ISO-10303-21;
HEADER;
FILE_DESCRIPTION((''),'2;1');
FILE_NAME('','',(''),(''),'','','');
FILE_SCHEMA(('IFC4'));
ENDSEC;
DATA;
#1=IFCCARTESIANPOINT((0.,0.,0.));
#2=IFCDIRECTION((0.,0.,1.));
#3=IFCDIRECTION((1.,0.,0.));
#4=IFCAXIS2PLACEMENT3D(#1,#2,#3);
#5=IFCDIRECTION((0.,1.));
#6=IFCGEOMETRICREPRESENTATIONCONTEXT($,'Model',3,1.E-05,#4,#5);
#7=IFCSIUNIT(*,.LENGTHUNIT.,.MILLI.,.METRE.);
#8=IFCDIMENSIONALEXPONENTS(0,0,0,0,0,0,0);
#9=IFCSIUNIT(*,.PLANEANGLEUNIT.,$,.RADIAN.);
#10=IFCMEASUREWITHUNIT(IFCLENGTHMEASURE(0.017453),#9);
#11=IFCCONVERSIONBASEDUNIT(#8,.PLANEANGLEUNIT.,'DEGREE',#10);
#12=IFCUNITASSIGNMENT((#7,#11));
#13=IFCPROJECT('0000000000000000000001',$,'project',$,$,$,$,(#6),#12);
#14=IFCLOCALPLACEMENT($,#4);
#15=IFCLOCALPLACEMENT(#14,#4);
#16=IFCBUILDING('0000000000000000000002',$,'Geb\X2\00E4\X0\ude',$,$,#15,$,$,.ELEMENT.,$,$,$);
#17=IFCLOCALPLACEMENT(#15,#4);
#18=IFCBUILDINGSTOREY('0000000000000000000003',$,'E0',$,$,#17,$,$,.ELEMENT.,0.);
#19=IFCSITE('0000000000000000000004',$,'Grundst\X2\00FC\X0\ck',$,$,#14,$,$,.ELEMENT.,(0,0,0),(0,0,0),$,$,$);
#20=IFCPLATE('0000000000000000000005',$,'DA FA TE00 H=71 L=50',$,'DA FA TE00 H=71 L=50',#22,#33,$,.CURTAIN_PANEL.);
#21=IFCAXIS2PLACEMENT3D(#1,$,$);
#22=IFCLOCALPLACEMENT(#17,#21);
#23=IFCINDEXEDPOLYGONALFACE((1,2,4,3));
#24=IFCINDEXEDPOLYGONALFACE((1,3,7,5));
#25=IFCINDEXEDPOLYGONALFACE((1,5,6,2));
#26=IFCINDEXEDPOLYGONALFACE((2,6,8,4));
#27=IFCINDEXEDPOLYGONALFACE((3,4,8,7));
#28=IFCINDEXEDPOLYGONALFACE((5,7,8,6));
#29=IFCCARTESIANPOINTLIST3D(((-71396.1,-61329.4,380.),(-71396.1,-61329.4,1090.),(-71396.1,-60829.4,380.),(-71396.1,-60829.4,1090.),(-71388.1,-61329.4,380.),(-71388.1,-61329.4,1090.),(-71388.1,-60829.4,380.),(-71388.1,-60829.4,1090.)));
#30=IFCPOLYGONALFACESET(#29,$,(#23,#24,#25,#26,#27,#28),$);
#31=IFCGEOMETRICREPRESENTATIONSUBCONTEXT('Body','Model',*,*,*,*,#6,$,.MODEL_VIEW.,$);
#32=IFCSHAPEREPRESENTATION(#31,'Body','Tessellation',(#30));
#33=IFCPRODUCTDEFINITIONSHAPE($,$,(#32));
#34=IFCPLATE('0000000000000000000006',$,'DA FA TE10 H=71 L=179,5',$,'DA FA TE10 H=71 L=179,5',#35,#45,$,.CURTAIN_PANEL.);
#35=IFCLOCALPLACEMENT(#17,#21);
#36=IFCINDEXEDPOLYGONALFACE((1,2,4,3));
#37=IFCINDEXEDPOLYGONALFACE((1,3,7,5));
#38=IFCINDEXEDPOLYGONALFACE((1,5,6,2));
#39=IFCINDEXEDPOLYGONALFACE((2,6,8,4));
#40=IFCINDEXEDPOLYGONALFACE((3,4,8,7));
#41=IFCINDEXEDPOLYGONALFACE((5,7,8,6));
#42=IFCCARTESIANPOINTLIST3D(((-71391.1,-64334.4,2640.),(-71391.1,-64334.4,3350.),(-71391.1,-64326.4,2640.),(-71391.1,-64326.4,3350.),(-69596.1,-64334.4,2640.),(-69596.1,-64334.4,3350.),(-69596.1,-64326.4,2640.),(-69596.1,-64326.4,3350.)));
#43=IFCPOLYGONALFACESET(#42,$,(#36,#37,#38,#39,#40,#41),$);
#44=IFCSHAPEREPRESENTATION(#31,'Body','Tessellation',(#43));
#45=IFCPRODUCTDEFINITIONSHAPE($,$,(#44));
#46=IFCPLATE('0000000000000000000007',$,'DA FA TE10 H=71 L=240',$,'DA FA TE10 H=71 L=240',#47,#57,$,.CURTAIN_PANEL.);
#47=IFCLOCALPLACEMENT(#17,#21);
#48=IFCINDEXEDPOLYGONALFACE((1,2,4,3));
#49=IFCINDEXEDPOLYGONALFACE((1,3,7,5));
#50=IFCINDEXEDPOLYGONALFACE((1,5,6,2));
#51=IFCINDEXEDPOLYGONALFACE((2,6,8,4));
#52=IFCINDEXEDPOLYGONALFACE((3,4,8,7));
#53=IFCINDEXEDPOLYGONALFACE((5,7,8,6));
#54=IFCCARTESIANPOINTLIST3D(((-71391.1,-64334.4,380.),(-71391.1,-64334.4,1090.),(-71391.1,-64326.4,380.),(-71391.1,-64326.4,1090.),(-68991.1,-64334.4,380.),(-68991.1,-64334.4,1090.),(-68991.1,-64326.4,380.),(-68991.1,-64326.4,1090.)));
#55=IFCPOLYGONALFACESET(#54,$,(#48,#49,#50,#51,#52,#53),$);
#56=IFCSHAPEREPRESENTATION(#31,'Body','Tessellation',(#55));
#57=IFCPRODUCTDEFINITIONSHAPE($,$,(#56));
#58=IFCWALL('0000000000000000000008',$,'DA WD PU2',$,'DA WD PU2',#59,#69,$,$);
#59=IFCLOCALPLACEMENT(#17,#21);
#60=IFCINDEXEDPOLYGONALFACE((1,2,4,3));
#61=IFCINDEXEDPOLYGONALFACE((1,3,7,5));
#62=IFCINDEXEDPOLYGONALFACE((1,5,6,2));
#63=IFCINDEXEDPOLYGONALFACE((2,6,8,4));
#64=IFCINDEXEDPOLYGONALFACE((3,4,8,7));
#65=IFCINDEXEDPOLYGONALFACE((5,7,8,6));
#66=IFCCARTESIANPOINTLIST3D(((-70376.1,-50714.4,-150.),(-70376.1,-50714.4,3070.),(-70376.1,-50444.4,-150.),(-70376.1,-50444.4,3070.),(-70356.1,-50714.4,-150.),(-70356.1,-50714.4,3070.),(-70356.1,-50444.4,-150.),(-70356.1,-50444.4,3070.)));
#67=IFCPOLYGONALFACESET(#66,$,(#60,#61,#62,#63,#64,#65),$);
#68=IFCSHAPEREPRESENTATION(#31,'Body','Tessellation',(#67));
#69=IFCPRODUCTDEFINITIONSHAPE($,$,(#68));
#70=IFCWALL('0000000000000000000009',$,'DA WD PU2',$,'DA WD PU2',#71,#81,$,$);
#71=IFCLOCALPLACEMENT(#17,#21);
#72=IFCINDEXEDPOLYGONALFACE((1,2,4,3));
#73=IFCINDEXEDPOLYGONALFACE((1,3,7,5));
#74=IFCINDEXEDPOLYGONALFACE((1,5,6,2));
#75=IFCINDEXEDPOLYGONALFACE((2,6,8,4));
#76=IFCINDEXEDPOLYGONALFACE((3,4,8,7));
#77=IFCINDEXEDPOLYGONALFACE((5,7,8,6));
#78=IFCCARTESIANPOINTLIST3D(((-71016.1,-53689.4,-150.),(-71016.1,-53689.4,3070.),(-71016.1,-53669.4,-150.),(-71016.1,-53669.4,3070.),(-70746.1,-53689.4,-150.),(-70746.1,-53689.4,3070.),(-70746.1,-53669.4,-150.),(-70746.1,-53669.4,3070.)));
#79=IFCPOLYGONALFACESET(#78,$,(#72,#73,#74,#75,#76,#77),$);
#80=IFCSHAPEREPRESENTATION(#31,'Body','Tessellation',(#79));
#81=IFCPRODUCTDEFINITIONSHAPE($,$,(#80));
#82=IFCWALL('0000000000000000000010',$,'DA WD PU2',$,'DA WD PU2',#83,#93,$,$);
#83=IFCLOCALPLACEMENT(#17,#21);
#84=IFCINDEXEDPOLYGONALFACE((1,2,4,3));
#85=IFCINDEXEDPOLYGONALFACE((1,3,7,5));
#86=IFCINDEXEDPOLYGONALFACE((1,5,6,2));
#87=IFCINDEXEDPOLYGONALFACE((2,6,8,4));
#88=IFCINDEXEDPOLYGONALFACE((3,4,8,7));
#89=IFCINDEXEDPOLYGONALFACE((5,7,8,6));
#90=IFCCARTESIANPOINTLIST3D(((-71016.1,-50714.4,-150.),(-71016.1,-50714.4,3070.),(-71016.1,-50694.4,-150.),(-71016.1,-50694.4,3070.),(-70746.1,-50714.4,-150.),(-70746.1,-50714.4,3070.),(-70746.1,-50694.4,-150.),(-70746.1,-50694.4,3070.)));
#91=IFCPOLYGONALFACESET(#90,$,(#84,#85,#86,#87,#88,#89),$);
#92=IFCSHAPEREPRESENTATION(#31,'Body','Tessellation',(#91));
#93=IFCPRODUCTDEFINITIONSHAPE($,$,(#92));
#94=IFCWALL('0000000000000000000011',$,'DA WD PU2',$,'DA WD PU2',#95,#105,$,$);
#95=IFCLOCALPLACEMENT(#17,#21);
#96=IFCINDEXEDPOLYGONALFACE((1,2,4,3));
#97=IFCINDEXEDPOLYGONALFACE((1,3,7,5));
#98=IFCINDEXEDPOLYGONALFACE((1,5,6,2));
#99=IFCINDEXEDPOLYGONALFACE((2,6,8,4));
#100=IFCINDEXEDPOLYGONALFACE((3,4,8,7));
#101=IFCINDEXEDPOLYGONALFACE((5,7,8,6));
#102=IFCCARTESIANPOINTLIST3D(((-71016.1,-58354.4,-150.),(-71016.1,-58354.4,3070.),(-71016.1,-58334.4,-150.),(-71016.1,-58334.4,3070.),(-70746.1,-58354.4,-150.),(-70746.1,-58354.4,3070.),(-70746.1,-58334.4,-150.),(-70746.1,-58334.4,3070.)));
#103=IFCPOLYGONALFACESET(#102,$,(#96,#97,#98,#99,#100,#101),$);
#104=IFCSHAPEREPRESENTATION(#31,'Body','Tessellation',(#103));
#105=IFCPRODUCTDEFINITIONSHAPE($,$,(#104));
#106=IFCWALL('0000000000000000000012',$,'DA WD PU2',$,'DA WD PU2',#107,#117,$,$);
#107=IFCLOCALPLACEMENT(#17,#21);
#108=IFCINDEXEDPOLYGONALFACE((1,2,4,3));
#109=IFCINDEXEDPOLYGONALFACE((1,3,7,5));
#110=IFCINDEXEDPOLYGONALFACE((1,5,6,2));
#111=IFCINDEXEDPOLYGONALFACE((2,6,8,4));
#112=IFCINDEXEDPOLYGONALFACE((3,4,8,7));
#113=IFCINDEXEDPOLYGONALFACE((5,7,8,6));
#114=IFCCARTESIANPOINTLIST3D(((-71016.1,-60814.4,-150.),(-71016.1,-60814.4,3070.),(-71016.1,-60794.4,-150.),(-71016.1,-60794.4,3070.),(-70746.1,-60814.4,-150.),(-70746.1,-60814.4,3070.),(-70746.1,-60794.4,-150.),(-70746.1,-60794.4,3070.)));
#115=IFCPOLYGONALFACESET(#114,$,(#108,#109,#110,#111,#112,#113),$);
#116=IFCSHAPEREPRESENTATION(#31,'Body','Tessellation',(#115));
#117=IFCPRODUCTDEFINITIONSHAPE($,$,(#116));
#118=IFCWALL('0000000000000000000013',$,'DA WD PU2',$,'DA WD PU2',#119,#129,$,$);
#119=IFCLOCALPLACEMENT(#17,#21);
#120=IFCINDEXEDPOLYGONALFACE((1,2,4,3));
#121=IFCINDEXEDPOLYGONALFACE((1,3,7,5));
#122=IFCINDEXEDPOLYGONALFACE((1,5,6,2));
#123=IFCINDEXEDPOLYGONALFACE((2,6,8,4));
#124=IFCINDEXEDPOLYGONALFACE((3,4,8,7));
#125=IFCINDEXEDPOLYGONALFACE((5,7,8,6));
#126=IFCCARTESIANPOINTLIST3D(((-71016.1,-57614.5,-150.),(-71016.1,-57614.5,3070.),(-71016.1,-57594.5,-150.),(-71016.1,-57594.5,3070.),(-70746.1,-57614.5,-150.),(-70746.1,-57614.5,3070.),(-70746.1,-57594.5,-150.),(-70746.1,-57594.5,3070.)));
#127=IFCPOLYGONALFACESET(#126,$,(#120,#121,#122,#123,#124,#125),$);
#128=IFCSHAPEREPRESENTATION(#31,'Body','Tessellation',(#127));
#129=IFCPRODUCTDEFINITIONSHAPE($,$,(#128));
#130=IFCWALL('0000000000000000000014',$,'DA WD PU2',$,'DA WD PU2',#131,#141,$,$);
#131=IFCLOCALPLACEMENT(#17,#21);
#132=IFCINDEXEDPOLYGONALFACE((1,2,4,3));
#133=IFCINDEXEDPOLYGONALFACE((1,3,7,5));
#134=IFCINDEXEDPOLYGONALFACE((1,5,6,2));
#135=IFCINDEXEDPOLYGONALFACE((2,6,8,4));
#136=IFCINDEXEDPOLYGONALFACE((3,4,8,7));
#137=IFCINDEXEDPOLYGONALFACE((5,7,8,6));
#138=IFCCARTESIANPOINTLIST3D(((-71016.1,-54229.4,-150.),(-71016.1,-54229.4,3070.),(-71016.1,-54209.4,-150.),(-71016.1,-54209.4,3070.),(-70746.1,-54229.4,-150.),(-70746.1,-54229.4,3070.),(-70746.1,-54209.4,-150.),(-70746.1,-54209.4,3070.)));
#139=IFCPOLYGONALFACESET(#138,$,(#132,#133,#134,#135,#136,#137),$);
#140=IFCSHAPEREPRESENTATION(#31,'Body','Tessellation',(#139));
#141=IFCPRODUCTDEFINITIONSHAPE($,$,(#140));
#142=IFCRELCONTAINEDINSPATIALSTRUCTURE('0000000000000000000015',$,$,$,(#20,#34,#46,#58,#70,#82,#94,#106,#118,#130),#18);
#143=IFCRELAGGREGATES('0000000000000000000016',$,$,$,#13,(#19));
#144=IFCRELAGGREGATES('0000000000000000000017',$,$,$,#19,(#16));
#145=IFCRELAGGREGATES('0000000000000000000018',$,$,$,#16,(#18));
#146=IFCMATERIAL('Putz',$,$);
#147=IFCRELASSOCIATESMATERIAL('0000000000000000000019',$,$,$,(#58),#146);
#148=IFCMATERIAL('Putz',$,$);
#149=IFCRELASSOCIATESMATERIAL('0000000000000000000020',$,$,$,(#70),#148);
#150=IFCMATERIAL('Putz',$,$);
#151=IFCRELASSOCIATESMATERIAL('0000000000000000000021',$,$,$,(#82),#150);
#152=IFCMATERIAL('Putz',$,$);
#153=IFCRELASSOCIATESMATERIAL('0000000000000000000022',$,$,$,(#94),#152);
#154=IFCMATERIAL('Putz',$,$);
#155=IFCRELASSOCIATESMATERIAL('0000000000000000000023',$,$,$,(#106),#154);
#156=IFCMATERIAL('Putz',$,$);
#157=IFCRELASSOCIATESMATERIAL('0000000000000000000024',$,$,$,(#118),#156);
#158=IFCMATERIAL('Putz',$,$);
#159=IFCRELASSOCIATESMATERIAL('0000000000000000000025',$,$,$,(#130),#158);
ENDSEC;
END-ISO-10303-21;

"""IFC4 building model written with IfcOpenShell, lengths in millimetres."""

from ifc_helpers import new_model, entity, si_unit, converted_unit, direction, frame, origin_with_axes, place, context, subcontext, project, spatial, line, indexed_curve, outline, extrude, material, element, save


model = new_model("IFC4")

# Units and contexts
model_context = context("Model", 3, precision=1e-05, world=origin_with_axes(), true_north=direction((0.0, 1.0)))
body_context = subcontext(model_context, "Body", "Model", "MODEL_VIEW")
ifc_project = project(units=[si_unit("LENGTHUNIT", "METRE", prefix="MILLI"), converted_unit("PLANEANGLEUNIT", "DEGREE", entity("IfcLengthMeasure", 0.017453), si_unit("PLANEANGLEUNIT", "RADIAN"), dimensions=[0, 0, 0, 0, 0, 0, 0])], contexts=[model_context])

# Site, building, storey
site_placement = place(None, origin_with_axes())
site = spatial("IfcSite", under=ifc_project, at=site_placement, Name="Grundstück", CompositionType="ELEMENT", RefLatitude=(0, 0, 0), RefLongitude=(0, 0, 0))
building_placement = place(site_placement, origin_with_axes())
building = spatial("IfcBuilding", under=site, at=building_placement, Name="Gebäude", CompositionType="ELEMENT")
storey_placement = place(building_placement, origin_with_axes())
storey = spatial("IfcBuildingStorey", under=building, at=storey_placement, Name="E0", CompositionType="ELEMENT", Elevation=0.0)

# Plates
plate_1_placement = place(storey_placement, frame((-71396.1, -61079.4, 380.0), z_axis=(0.0, 0.0, 1.0), x_axis=(0.0, -1.0, 0.0)))
element("IfcPlate", 1, at=plate_1_placement, inside=storey, Name="DA FA TE00 H=71 L=50", ObjectType="DA FA TE00 H=71 L=50", PredefinedType="CURTAIN_PANEL", context=body_context, shape_type="SweptSolid", body=[
    extrude(outline(indexed_curve([(-250.0, 0.0), (250.0, 0.0), (250.0, 8.0), (-250.0, 8.0)], segments=[line(1, 2), line(2, 3), line(3, 4), line(4, 1)])), frame((0.0, 0.0, 710.0), z_axis=(0.0, 0.0, 1.0), x_axis=(1.0, 0.0, 0.0)), (0.0, 0.0, -1.0), 710.0),
])
plate_2_placement = place(storey_placement, frame((-70493.6, -64334.4, 2640.0), z_axis=(0.0, 0.0, 1.0), x_axis=(1.0, 0.0, 0.0)))
element("IfcPlate", 2, at=plate_2_placement, inside=storey, Name="DA FA TE10 H=71 L=179,5", ObjectType="DA FA TE10 H=71 L=179,5", PredefinedType="CURTAIN_PANEL", context=body_context, shape_type="SweptSolid", body=[
    extrude(outline(indexed_curve([(-897.5, 0.0), (897.5, 0.0), (897.5, 8.0), (-897.5, 8.0)], segments=[line(1, 2), line(2, 3), line(3, 4), line(4, 1)])), frame((0.0, 0.0, 710.0), z_axis=(0.0, 0.0, 1.0), x_axis=(1.0, 0.0, 0.0)), (0.0, 0.0, -1.0), 710.0),
])
plate_3_placement = place(storey_placement, frame((-70191.1, -64334.4, 380.0), z_axis=(0.0, 0.0, 1.0), x_axis=(1.0, 0.0, 0.0)))
element("IfcPlate", 3, at=plate_3_placement, inside=storey, Name="DA FA TE10 H=71 L=240", ObjectType="DA FA TE10 H=71 L=240", PredefinedType="CURTAIN_PANEL", context=body_context, shape_type="SweptSolid", body=[
    extrude(outline(indexed_curve([(-1200.0, 0.0), (1200.0, 0.0), (1200.0, 8.0), (-1200.0, 8.0)], segments=[line(1, 2), line(2, 3), line(3, 4), line(4, 1)])), frame((0.0, 0.0, 710.0), z_axis=(0.0, 0.0, 1.0), x_axis=(1.0, 0.0, 0.0)), (0.0, 0.0, -1.0), 710.0),
])

# Walls
ifc_material_1 = material(Name="Putz")
wall_1_placement = place(storey_placement, frame((-70366.1, -50714.4, -150.0), z_axis=(0.0, 0.0, 1.0), x_axis=(0.0, 1.0, 0.0)))
element("IfcWall", 4, at=wall_1_placement, inside=storey, material=ifc_material_1, Name="DA WD PU2", ObjectType="DA WD PU2", context=body_context, shape_type="SweptSolid", body=[
    extrude(outline(indexed_curve([(0.0, -10.0), (0.0, 10.0), (270.0, 10.0), (270.0, -10.0)], segments=[line(1, 2), line(2, 3), line(3, 4), line(4, 1)])), origin_with_axes(), (0.0, 0.0, 1.0), 3220.0),
])
ifc_material_2 = material(Name="Putz")
wall_2_placement = place(storey_placement, frame((-70746.1, -53679.4, -150.0), z_axis=(0.0, 0.0, 1.0), x_axis=(-1.0, 0.0, 0.0)))
element("IfcWall", 5, at=wall_2_placement, inside=storey, material=ifc_material_2, Name="DA WD PU2", ObjectType="DA WD PU2", context=body_context, shape_type="SweptSolid", body=[
    extrude(outline(indexed_curve([(0.0, -10.0), (0.0, 10.0), (270.0, 10.0), (270.0, -10.0)], segments=[line(1, 2), line(2, 3), line(3, 4), line(4, 1)])), origin_with_axes(), (0.0, 0.0, 1.0), 3220.0),
])
ifc_material_3 = material(Name="Putz")
wall_3_placement = place(storey_placement, frame((-70746.1, -50704.4, -150.0), z_axis=(0.0, 0.0, 1.0), x_axis=(-1.0, 0.0, 0.0)))
element("IfcWall", 6, at=wall_3_placement, inside=storey, material=ifc_material_3, Name="DA WD PU2", ObjectType="DA WD PU2", context=body_context, shape_type="SweptSolid", body=[
    extrude(outline(indexed_curve([(0.0, -10.0), (0.0, 10.0), (270.0, 10.0), (270.0, -10.0)], segments=[line(1, 2), line(2, 3), line(3, 4), line(4, 1)])), origin_with_axes(), (0.0, 0.0, 1.0), 3220.0),
])
ifc_material_4 = material(Name="Putz")
wall_4_placement = place(storey_placement, frame((-71016.1, -58344.4, -150.0), z_axis=(0.0, 0.0, 1.0), x_axis=(1.0, 0.0, 0.0)))
element("IfcWall", 7, at=wall_4_placement, inside=storey, material=ifc_material_4, Name="DA WD PU2", ObjectType="DA WD PU2", context=body_context, shape_type="SweptSolid", body=[
    extrude(outline(indexed_curve([(0.0, -10.0), (0.0, 10.0), (270.0, 10.0), (270.0, -10.0)], segments=[line(1, 2), line(2, 3), line(3, 4), line(4, 1)])), origin_with_axes(), (0.0, 0.0, 1.0), 3220.0),
])
ifc_material_5 = material(Name="Putz")
wall_5_placement = place(storey_placement, frame((-71016.1, -60804.4, -150.0), z_axis=(0.0, 0.0, 1.0), x_axis=(1.0, 0.0, 0.0)))
element("IfcWall", 8, at=wall_5_placement, inside=storey, material=ifc_material_5, Name="DA WD PU2", ObjectType="DA WD PU2", context=body_context, shape_type="SweptSolid", body=[
    extrude(outline(indexed_curve([(0.0, -10.0), (0.0, 10.0), (270.0, 10.0), (270.0, -10.0)], segments=[line(1, 2), line(2, 3), line(3, 4), line(4, 1)])), origin_with_axes(), (0.0, 0.0, 1.0), 3220.0),
])
ifc_material_6 = material(Name="Putz")
wall_6_placement = place(storey_placement, frame((-70746.1, -57604.5, -150.0), z_axis=(0.0, 0.0, 1.0), x_axis=(-1.0, 0.0, 0.0)))
element("IfcWall", 9, at=wall_6_placement, inside=storey, material=ifc_material_6, Name="DA WD PU2", ObjectType="DA WD PU2", context=body_context, shape_type="SweptSolid", body=[
    extrude(outline(indexed_curve([(0.0, -10.0), (0.0, 10.0), (270.0, 10.0), (270.0, -10.0)], segments=[line(1, 2), line(2, 3), line(3, 4), line(4, 1)])), origin_with_axes(), (0.0, 0.0, 1.0), 3220.0),
])
ifc_material_7 = material(Name="Putz")
wall_7_placement = place(storey_placement, frame((-70746.1, -54219.4, -150.0), z_axis=(0.0, 0.0, 1.0), x_axis=(-1.0, 0.0, 0.0)))
element("IfcWall", 10, at=wall_7_placement, inside=storey, material=ifc_material_7, Name="DA WD PU2", ObjectType="DA WD PU2", context=body_context, shape_type="SweptSolid", body=[
    extrude(outline(indexed_curve([(0.0, -10.0), (0.0, 10.0), (270.0, 10.0), (270.0, -10.0)], segments=[line(1, 2), line(2, 3), line(3, 4), line(4, 1)])), origin_with_axes(), (0.0, 0.0, 1.0), 3220.0),
])

save(model, "model.ifc")
